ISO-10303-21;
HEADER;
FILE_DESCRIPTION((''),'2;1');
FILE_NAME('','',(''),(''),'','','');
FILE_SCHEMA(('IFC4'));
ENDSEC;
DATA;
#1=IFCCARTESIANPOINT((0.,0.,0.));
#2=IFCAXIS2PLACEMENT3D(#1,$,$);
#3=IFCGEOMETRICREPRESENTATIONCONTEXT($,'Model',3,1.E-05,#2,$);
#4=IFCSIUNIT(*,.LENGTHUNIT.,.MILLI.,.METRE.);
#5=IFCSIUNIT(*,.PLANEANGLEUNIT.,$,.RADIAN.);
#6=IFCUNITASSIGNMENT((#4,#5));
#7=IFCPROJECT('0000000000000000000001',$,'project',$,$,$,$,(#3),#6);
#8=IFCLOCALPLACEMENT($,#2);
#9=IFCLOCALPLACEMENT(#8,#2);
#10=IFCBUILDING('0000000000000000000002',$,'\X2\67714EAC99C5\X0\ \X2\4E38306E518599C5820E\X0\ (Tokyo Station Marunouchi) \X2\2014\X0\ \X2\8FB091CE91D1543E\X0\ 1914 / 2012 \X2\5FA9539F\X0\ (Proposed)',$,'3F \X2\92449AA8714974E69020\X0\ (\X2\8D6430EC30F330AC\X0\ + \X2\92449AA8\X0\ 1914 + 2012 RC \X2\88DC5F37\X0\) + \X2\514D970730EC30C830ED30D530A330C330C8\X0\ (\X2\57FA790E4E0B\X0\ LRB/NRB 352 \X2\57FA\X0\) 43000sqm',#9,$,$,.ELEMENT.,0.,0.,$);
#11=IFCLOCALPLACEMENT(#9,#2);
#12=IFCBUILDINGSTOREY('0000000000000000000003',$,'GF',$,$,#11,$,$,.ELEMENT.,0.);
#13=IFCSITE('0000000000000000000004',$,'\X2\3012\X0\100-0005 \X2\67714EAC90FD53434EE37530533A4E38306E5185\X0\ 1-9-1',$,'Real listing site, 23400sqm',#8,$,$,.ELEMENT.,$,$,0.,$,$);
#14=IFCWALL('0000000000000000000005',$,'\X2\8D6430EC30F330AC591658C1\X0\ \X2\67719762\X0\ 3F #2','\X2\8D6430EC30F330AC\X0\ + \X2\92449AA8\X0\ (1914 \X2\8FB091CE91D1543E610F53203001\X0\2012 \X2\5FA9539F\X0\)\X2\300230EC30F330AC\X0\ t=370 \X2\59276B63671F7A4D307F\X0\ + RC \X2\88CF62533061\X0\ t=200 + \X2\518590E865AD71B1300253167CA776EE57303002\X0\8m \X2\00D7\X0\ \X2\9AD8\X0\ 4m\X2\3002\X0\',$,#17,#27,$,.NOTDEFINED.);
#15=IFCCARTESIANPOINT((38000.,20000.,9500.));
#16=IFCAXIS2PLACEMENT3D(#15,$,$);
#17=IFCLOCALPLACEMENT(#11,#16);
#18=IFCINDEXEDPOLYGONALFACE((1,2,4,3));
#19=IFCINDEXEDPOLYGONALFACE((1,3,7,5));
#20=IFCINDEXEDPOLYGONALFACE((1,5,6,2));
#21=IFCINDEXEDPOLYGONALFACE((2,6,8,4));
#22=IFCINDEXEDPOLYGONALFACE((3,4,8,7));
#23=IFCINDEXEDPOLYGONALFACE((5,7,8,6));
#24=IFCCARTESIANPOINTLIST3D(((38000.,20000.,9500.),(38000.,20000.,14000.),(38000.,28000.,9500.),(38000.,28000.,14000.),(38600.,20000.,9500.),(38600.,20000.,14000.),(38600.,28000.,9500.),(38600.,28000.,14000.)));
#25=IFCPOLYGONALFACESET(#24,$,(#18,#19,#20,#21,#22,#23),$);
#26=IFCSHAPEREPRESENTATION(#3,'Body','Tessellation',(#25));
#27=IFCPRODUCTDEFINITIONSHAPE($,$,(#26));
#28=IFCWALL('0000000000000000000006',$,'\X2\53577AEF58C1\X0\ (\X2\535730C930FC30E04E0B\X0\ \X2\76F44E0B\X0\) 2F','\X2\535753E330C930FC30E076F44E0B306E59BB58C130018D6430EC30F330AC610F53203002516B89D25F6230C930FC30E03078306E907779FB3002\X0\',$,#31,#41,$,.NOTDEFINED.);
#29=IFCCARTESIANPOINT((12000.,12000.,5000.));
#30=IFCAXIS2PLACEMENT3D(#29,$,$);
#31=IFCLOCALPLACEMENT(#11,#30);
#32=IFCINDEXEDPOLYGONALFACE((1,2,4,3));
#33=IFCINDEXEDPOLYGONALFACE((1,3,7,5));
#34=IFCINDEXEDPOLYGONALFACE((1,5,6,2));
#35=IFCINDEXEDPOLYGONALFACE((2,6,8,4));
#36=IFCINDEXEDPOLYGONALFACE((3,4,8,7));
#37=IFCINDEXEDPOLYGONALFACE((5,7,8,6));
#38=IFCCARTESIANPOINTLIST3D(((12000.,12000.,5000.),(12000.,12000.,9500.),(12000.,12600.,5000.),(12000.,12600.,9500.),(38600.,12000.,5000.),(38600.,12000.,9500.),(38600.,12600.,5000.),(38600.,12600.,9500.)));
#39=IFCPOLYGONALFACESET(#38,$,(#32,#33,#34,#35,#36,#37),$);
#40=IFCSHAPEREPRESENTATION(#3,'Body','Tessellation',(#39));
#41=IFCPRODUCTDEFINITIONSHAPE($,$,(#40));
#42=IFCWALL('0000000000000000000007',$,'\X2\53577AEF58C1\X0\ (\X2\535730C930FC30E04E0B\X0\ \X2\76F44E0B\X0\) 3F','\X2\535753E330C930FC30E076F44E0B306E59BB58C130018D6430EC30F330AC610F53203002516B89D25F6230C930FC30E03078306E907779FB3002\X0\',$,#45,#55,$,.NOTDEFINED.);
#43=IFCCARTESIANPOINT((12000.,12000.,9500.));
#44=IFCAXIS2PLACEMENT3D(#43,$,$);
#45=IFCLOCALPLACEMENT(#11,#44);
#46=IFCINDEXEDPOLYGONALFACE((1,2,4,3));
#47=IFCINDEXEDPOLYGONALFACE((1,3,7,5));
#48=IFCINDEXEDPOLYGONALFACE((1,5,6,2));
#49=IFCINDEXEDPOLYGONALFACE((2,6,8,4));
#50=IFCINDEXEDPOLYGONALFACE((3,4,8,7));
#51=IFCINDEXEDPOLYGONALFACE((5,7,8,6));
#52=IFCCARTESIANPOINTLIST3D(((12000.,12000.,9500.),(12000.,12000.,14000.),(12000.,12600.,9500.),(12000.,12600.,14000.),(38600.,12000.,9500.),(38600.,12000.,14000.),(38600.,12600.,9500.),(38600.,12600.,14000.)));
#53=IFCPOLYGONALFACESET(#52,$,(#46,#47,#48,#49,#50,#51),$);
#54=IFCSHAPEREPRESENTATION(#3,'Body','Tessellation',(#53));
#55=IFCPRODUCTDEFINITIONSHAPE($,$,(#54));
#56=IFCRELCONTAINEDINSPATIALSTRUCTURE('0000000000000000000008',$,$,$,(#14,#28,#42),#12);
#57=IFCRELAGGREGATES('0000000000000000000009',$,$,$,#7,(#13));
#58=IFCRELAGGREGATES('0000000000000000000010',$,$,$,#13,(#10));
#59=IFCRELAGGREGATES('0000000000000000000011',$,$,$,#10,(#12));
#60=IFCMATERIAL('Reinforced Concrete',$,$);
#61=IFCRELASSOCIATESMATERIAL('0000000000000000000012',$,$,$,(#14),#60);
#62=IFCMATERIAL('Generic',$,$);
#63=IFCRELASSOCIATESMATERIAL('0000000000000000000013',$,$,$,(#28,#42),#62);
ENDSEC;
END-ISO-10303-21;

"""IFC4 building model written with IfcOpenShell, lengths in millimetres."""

from ifc_helpers import new_model, si_unit, frame, frame_2d, origin, place, context, project, spatial, rectangle, extrude, material, element, save


model = new_model("IFC4")

# Units and contexts
model_context = context("Model", 3, precision=1e-05, world=origin())
ifc_project = project(units=[si_unit("LENGTHUNIT", "METRE", prefix="MILLI"), si_unit("PLANEANGLEUNIT", "RADIAN")], contexts=[model_context])

# Site, building, storey
site_placement = place(None, origin())
site = spatial("IfcSite", under=ifc_project, at=site_placement, Name="〒100-0005 東京都千代田区丸の内 1-9-1", ObjectType="Real listing site, 23400sqm", CompositionType="ELEMENT", RefElevation=0.0)
building_placement = place(site_placement, origin())
building = spatial("IfcBuilding", under=site, at=building_placement, Name="東京駅 丸の内駅舎 (Tokyo Station Marunouchi) — 辰野金吾 1914 / 2012 復原 (Proposed)", ObjectType="3F 鉄骨煉瓦造 (赤レンガ + 鉄骨 1914 + 2012 RC 補強) + 免震レトロフィット (基礎下 LRB/NRB 352 基) 43000sqm", CompositionType="ELEMENT", ElevationOfRefHeight=0.0, ElevationOfTerrain=0.0)
storey_placement = place(building_placement, origin())
storey = spatial("IfcBuildingStorey", under=building, at=storey_placement, Name="GF", CompositionType="ELEMENT", Elevation=0.0)

# Shared definitions
ifc_material_1 = material(Name="Reinforced Concrete")
ifc_material_2 = material(Name="Generic")

# Walls
wall_1_placement = place(storey_placement, frame((38000.0, 20000.0, 9500.0)))
element("IfcWall", 1, at=wall_1_placement, inside=storey, material=ifc_material_1, Name="赤レンガ外壁 東面 3F #2", Description="赤レンガ + 鉄骨 (1914 辰野金吾意匠、2012 復原)。レンガ t=370 大正期積み + RC 裏打ち t=200 + 内部断熱。化粧目地。8m × 高 4m。", PredefinedType="NOTDEFINED", context=model_context, shape_type="SweptSolid", body=[
    extrude(rectangle(XDim=600.0, YDim=8000.0, at=frame_2d((300.0, 4000.0))), frame((38000.0, 20000.0, 9500.0)), (0.0, 0.0, 1.0), 4500.0),
])
wall_2_placement = place(storey_placement, frame((12000.0, 12000.0, 5000.0)))
element("IfcWall", 2, at=wall_2_placement, inside=storey, material=ifc_material_2, Name="南端壁 (南ドーム下 直下) 2F", Description="南口ドーム直下の妻壁、赤レンガ意匠。八角形ドームへの遷移。", PredefinedType="NOTDEFINED", context=model_context, shape_type="SweptSolid", body=[
    extrude(rectangle(XDim=26600.0, YDim=600.0, at=frame_2d((13300.0, 300.0))), frame((12000.0, 12000.0, 5000.0)), (0.0, 0.0, 1.0), 4500.0),
])
wall_3_placement = place(storey_placement, frame((12000.0, 12000.0, 9500.0)))
element("IfcWall", 3, at=wall_3_placement, inside=storey, material=ifc_material_2, Name="南端壁 (南ドーム下 直下) 3F", Description="南口ドーム直下の妻壁、赤レンガ意匠。八角形ドームへの遷移。", PredefinedType="NOTDEFINED", context=model_context, shape_type="SweptSolid", body=[
    extrude(rectangle(XDim=26600.0, YDim=600.0, at=frame_2d((13300.0, 300.0))), frame((12000.0, 12000.0, 9500.0)), (0.0, 0.0, 1.0), 4500.0),
])

save(model, "model.ifc")
